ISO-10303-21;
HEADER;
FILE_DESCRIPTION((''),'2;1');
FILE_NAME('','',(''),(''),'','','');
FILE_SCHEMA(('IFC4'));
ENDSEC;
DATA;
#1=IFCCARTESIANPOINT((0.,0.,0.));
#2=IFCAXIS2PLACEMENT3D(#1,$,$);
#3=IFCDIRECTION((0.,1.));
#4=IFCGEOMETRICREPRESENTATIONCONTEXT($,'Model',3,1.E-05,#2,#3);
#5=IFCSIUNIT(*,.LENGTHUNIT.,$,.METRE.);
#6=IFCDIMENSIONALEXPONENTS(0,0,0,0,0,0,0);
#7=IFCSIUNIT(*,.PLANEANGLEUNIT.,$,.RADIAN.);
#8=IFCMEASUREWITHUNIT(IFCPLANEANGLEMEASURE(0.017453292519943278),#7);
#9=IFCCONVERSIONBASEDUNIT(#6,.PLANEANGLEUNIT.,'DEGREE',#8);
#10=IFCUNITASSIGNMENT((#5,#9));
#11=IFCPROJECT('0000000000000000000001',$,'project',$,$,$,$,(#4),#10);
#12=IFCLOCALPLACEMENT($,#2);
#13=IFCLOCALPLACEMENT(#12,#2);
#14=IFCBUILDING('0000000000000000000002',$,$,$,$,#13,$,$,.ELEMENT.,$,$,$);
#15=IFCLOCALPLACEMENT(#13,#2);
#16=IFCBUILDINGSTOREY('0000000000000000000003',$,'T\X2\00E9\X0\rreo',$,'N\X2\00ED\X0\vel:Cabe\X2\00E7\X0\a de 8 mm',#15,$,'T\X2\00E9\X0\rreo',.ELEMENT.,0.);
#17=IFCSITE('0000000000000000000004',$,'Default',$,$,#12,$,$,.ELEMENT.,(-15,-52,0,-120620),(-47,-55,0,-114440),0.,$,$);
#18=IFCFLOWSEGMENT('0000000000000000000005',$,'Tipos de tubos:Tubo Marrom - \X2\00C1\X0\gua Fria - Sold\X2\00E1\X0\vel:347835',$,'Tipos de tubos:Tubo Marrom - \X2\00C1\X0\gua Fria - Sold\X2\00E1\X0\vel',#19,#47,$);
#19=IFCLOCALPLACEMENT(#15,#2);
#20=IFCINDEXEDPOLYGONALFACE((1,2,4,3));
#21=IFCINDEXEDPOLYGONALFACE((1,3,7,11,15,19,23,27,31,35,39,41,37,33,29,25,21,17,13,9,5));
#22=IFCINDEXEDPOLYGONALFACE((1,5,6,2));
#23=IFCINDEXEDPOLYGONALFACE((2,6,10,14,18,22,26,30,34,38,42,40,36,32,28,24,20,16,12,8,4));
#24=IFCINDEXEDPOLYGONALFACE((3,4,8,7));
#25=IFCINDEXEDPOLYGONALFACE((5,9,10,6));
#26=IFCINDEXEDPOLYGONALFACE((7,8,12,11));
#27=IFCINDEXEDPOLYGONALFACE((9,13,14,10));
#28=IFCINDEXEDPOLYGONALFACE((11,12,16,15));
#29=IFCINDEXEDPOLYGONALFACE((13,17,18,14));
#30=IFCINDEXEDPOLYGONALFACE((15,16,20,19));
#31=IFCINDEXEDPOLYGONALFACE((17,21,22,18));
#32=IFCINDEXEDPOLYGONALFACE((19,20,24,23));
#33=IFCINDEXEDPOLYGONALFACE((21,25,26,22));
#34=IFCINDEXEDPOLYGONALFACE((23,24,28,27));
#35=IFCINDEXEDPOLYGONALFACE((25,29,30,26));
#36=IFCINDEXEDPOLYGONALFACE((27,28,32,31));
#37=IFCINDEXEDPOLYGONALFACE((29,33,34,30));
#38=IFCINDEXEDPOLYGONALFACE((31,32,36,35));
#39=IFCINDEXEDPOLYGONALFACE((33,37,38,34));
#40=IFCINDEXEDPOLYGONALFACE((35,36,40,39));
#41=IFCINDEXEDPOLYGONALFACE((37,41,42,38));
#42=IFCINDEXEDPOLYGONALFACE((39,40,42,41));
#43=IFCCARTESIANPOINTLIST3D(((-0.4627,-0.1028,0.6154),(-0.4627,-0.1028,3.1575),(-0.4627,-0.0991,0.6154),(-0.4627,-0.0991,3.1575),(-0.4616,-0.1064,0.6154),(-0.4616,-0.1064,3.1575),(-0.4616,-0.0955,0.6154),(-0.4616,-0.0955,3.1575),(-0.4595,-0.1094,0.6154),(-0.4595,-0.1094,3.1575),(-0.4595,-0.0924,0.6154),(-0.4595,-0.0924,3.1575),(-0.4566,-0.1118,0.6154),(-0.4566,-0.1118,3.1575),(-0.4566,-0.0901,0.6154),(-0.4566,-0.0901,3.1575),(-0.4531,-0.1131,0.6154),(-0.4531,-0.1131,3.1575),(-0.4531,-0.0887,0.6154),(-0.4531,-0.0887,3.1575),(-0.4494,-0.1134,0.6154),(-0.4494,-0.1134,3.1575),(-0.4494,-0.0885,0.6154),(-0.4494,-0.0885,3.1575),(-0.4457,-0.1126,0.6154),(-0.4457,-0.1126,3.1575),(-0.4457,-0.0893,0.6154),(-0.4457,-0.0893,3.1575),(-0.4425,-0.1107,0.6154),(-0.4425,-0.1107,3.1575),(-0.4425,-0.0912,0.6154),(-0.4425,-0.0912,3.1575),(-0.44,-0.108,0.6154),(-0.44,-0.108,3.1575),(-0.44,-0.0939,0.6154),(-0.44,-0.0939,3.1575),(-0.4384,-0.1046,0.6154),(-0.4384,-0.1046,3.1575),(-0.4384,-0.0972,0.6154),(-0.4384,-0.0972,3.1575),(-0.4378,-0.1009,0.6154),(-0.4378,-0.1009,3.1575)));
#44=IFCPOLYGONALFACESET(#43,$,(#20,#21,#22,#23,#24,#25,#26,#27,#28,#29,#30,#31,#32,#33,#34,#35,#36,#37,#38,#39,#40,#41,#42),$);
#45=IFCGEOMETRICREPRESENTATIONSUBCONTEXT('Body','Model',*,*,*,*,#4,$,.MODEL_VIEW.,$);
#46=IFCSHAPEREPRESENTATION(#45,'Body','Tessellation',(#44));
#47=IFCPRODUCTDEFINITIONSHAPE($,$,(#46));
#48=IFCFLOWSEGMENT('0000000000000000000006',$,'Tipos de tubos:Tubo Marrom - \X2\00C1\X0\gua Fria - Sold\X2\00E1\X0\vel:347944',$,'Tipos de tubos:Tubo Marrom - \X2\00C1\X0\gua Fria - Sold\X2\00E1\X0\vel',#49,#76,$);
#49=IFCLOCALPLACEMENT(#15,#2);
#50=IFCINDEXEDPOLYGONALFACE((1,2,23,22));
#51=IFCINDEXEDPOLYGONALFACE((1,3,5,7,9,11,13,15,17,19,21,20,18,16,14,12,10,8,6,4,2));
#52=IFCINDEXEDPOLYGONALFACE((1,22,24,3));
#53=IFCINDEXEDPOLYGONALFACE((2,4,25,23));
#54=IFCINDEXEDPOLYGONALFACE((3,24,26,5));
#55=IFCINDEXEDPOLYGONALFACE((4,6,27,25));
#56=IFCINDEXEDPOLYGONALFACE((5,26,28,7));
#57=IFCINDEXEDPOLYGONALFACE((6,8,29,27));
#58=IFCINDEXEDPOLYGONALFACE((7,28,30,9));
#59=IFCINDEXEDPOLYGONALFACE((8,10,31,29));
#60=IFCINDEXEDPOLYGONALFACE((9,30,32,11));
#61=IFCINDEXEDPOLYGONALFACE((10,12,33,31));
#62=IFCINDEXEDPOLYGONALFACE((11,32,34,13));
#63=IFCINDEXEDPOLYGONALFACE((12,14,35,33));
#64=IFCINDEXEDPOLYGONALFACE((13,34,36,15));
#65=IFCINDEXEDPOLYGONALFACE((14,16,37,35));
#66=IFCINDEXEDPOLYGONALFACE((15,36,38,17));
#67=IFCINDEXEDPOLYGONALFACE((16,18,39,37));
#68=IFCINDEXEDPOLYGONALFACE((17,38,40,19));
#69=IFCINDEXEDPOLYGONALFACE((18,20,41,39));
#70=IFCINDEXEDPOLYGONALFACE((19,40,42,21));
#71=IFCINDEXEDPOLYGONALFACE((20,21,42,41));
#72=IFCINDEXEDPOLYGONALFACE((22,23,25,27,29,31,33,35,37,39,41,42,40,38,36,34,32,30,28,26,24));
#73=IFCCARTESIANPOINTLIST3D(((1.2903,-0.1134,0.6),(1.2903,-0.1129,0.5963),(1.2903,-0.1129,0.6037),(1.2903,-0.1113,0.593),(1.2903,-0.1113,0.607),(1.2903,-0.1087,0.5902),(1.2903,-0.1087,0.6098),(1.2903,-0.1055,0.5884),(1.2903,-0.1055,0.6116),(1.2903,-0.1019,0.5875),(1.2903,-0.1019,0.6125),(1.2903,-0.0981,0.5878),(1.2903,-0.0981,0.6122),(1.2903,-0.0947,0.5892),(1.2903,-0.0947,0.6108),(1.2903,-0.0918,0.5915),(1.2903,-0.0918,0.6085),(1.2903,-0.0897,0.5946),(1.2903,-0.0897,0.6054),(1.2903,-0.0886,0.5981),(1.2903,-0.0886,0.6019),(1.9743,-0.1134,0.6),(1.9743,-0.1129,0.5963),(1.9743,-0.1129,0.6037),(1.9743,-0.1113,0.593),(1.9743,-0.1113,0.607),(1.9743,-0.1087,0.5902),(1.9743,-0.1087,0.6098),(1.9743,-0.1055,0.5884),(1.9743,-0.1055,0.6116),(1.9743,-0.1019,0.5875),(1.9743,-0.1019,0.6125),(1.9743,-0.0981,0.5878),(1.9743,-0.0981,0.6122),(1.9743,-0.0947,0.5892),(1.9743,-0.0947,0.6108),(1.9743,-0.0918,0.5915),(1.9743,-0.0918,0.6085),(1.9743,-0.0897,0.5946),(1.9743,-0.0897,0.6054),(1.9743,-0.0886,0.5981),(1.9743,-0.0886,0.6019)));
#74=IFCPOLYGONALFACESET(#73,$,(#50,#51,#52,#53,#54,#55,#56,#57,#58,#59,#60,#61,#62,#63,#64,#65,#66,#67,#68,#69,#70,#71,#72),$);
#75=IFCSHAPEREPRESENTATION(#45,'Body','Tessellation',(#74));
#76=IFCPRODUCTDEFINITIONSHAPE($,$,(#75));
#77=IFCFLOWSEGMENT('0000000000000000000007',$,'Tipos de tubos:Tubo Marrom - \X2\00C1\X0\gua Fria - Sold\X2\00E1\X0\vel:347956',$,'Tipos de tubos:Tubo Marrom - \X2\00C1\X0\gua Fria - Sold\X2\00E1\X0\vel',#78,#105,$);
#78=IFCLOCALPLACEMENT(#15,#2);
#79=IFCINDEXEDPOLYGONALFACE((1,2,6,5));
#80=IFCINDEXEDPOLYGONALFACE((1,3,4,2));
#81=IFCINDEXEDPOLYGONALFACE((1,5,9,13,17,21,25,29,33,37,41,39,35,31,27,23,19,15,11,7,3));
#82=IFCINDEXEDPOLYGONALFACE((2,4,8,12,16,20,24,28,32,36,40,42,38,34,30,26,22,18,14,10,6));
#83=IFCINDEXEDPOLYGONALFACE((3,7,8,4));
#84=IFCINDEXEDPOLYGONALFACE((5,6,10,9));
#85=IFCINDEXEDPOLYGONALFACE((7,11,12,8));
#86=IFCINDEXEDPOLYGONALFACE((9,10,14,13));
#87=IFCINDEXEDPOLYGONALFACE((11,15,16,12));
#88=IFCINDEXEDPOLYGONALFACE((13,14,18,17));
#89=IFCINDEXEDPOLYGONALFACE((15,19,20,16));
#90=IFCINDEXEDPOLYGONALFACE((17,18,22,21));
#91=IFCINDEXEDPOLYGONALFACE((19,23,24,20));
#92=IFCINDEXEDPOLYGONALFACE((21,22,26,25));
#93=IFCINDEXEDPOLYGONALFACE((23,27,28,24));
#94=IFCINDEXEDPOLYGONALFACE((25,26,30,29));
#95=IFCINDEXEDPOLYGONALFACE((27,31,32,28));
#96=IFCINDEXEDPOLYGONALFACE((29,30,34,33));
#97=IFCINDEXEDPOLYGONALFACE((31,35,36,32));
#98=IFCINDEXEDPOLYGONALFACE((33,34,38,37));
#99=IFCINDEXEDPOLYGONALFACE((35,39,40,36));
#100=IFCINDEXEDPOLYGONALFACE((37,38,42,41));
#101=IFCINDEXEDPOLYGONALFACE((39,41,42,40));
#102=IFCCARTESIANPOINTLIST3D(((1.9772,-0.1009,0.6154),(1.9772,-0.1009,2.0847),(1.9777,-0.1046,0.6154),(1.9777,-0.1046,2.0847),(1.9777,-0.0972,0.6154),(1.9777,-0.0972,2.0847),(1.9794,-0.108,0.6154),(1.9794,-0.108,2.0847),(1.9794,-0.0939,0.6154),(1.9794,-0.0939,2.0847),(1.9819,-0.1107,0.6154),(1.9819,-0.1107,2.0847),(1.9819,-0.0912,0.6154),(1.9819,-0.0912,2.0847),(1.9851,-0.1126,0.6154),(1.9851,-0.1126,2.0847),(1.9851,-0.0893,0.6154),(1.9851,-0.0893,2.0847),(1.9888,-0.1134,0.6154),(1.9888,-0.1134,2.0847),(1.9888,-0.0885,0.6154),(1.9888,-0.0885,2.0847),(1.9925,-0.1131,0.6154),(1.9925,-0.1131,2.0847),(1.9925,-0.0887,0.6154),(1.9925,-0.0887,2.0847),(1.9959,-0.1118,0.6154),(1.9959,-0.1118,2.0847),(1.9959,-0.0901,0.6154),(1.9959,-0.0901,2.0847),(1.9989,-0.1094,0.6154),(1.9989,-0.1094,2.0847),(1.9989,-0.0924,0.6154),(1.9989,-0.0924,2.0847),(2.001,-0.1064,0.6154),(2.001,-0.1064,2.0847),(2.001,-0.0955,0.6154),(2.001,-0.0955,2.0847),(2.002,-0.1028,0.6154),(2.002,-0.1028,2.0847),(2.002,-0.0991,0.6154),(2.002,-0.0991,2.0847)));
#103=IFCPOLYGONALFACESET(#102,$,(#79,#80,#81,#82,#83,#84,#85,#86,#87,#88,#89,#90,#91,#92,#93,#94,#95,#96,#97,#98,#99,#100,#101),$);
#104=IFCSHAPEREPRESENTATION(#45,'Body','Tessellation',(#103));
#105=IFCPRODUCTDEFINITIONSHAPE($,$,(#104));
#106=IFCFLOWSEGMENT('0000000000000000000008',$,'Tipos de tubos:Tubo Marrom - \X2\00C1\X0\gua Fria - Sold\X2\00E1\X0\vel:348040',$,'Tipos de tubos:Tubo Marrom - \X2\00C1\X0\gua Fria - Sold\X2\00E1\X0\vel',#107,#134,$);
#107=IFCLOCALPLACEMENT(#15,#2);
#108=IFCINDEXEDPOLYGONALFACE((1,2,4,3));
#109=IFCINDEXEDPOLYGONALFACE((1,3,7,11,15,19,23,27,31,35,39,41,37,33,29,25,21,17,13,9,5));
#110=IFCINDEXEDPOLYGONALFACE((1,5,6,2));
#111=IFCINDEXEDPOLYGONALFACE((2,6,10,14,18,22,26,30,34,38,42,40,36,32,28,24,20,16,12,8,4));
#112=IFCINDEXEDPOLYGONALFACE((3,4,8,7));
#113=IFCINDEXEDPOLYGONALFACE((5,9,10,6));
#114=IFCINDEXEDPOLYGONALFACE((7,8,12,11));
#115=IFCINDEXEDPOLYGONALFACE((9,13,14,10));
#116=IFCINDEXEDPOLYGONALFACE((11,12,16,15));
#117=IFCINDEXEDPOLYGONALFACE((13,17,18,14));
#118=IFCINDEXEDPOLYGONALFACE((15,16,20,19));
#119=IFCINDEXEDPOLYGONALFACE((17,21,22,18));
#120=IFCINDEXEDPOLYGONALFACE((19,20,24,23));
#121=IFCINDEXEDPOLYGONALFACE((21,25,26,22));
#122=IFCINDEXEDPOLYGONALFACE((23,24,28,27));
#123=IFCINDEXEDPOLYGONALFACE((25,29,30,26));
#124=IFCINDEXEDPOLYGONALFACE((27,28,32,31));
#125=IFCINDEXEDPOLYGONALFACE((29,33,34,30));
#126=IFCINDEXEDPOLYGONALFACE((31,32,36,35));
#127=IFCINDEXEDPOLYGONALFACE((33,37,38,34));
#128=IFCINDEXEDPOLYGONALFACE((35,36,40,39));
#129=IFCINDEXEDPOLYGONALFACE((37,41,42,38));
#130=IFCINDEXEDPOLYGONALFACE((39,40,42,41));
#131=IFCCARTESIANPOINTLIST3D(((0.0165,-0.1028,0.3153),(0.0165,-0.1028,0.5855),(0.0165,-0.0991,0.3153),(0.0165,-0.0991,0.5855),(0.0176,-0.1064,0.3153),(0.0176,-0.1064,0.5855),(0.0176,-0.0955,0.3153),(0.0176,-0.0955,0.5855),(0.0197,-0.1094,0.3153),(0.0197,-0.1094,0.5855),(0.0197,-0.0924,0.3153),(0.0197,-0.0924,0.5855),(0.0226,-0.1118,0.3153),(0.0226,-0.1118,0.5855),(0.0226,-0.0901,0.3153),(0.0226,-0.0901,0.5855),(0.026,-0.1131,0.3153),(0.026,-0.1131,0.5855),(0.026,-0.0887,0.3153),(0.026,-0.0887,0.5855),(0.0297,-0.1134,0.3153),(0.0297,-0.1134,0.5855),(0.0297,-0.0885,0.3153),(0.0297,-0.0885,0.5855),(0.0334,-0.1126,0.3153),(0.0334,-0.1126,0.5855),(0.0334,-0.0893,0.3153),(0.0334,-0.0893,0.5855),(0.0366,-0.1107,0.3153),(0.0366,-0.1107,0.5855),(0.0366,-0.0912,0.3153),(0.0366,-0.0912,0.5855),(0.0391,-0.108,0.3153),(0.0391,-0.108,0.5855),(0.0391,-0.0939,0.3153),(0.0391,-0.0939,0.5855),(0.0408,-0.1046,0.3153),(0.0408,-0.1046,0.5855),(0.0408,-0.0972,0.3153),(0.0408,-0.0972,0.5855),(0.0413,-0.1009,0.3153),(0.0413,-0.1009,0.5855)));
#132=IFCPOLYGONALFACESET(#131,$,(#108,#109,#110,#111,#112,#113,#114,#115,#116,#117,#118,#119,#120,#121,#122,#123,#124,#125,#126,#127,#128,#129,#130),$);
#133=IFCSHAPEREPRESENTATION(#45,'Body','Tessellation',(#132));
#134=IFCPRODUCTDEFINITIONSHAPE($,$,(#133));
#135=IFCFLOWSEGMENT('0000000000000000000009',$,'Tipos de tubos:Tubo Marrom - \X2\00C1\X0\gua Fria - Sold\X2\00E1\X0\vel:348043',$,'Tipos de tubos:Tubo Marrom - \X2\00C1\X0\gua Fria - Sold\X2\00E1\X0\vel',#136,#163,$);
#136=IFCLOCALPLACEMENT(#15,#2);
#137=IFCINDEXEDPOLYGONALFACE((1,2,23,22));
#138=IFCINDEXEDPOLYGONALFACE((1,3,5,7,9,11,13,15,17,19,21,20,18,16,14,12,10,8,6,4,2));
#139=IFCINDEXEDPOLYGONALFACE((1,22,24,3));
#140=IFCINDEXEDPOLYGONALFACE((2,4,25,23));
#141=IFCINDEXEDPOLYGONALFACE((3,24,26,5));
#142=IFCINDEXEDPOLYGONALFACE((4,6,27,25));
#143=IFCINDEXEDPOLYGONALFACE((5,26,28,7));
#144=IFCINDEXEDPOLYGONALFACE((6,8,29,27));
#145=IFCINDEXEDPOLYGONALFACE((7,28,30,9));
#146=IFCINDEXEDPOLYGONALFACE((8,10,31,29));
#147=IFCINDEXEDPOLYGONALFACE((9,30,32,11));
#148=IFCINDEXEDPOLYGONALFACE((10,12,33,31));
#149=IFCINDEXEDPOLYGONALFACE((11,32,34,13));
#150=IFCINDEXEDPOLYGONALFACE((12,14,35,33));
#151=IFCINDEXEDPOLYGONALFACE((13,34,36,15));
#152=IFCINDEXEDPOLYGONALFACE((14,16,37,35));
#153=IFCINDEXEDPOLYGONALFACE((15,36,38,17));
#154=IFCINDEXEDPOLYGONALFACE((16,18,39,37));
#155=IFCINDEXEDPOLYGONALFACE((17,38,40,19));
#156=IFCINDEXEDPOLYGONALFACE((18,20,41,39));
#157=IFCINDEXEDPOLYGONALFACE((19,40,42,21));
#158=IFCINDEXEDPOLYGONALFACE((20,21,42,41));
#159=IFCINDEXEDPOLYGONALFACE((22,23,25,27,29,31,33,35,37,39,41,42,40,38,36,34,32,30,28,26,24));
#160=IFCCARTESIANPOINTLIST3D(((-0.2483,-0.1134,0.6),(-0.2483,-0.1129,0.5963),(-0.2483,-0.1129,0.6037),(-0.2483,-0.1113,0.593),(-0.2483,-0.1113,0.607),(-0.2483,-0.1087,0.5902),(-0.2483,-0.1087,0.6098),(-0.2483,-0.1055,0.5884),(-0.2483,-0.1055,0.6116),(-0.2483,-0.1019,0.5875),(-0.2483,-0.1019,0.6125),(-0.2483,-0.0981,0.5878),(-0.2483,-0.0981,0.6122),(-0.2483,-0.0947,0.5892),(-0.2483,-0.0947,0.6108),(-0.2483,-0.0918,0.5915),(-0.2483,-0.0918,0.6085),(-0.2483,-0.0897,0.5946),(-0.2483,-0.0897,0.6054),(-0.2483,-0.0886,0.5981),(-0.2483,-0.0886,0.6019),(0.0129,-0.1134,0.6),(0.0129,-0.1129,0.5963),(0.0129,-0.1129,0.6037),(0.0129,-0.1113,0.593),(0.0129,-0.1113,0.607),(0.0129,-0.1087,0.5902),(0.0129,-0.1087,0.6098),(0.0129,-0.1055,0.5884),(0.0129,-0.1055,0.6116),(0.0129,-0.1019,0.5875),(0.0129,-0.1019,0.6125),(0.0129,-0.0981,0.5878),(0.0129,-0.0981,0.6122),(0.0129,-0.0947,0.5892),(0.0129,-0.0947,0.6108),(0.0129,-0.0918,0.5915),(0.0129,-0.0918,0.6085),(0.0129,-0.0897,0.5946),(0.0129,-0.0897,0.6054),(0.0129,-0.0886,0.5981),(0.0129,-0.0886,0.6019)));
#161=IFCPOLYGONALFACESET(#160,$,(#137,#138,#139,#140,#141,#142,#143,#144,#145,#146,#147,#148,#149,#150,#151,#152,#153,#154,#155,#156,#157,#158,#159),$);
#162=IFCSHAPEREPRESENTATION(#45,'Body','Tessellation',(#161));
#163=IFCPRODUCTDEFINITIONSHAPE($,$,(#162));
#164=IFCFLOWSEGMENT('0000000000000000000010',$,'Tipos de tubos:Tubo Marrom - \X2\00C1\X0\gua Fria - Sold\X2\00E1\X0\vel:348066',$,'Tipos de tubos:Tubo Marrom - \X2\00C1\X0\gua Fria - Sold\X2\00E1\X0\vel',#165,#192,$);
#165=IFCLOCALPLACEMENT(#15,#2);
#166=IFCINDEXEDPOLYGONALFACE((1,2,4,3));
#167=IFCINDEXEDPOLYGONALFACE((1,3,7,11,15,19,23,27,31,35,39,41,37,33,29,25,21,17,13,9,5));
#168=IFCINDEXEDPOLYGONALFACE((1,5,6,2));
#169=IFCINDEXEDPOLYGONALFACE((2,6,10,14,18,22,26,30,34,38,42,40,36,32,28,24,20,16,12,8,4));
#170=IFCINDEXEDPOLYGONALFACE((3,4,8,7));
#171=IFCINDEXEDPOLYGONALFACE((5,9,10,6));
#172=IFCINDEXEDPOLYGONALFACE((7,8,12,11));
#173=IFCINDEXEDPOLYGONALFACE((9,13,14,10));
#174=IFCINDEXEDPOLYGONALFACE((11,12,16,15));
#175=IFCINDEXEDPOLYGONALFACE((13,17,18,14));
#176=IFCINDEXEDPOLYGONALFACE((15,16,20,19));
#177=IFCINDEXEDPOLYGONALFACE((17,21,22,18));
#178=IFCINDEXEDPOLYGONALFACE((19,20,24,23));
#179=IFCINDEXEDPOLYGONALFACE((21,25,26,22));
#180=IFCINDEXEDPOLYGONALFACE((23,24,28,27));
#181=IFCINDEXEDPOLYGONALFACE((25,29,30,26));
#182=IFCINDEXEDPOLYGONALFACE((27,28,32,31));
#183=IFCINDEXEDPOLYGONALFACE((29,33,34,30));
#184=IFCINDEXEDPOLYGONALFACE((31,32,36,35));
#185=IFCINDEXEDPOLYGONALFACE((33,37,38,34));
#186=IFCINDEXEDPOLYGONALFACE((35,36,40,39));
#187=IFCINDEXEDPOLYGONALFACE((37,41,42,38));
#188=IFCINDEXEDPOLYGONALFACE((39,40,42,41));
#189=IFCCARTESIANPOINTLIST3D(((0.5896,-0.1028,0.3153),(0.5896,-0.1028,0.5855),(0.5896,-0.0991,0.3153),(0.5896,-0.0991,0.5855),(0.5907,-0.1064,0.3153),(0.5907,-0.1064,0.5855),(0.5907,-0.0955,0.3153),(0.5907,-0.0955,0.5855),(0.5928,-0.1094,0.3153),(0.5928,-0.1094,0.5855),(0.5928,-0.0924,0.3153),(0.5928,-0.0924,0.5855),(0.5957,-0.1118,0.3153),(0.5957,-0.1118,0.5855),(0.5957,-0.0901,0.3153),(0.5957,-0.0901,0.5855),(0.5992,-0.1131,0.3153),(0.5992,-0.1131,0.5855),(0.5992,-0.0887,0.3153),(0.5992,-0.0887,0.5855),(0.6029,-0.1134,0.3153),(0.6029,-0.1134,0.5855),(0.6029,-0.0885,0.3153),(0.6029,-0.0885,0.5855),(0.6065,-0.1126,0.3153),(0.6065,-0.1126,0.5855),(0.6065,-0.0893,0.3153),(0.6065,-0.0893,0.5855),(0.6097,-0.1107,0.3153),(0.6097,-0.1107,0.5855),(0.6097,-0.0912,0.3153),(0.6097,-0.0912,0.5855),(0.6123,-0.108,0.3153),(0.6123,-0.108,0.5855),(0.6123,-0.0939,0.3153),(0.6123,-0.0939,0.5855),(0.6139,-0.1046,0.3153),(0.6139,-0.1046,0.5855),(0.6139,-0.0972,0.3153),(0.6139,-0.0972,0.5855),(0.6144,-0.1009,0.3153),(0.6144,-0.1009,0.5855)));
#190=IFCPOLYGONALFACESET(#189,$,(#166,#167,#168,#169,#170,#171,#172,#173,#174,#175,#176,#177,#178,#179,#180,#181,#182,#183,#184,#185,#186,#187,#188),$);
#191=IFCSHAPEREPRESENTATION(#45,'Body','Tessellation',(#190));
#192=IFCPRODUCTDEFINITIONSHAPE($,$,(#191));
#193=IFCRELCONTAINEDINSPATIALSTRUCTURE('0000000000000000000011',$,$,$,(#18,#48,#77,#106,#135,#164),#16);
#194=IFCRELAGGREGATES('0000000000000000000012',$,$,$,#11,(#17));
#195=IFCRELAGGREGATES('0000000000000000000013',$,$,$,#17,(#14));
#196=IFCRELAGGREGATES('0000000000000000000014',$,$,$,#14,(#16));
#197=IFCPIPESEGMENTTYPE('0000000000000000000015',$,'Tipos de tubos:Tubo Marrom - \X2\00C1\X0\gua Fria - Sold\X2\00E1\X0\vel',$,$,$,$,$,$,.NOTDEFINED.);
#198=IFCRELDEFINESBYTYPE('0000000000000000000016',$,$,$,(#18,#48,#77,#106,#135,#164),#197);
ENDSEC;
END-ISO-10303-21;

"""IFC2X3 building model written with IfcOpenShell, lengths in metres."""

from ifc_helpers import new_model, entity, si_unit, converted_unit, direction, frame, frame_2d, origin, origin_2d_with_axis, place, context, subcontext, project, spatial, circle, extrude, type_object, element, save


model = new_model("IFC2X3")

# Units and contexts
model_context = context("Model", 3, precision=1e-05, world=origin(), true_north=direction((0.0, 1.0)))
body_context = subcontext(model_context, "Body", "Model", "MODEL_VIEW")
ifc_project = project(units=[si_unit("LENGTHUNIT", "METRE"), converted_unit("PLANEANGLEUNIT", "DEGREE", entity("IfcPlaneAngleMeasure", 0.017453292519943278), si_unit("PLANEANGLEUNIT", "RADIAN"), dimensions=[0, 0, 0, 0, 0, 0, 0])], contexts=[model_context])

# Site, building, storey
site_placement = place(None, origin())
site = spatial("IfcSite", under=ifc_project, at=site_placement, Name="Default", CompositionType="ELEMENT", RefLatitude=(-15, -52, 0, -120620), RefLongitude=(-47, -55, 0, -114440), RefElevation=0.0)
building_placement = place(site_placement, origin())
building = spatial("IfcBuilding", under=site, at=building_placement, CompositionType="ELEMENT")
storey_placement = place(building_placement, origin())
storey = spatial("IfcBuildingStorey", under=building, at=storey_placement, Name="Térreo", ObjectType="Nível:Cabeça de 8 mm", LongName="Térreo", CompositionType="ELEMENT", Elevation=0.0)

# Flow segments
pipe_segment_type = type_object("IfcPipeSegmentType", Name="Tipos de tubos:Tubo Marrom - Água Fria - Soldável", PredefinedType="NOTDEFINED")
flow_segment_1_placement = place(storey_placement, origin())
element("IfcFlowSegment", 1, at=flow_segment_1_placement, inside=storey, type_object=pipe_segment_type, Name="Tipos de tubos:Tubo Marrom - Água Fria - Soldável:347835", ObjectType="Tipos de tubos:Tubo Marrom - Água Fria - Soldável", context=body_context, shape_type="SweptSolid", body=[
    extrude(circle(Radius=0.0125, at=origin_2d_with_axis()), frame((-0.4503, -0.1009, 0.6154)), (0.0, 0.0, 1.0), 2.5421),
])
flow_segment_2_placement = place(storey_placement, origin())
element("IfcFlowSegment", 2, at=flow_segment_2_placement, inside=storey, type_object=pipe_segment_type, Name="Tipos de tubos:Tubo Marrom - Água Fria - Soldável:347944", ObjectType="Tipos de tubos:Tubo Marrom - Água Fria - Soldável", context=body_context, shape_type="SweptSolid", body=[
    extrude(circle(Radius=0.0125, at=frame_2d((0.0, 0.0), x_axis=(1.0, 0.0))), frame((1.2903, -0.1009, 0.6), z_axis=(1.0, 0.0, 0.0), x_axis=(0.0, -1.0, 0.0)), (0.0, 0.0, 1.0), 0.684),
])
flow_segment_3_placement = place(storey_placement, origin())
element("IfcFlowSegment", 3, at=flow_segment_3_placement, inside=storey, type_object=pipe_segment_type, Name="Tipos de tubos:Tubo Marrom - Água Fria - Soldável:347956", ObjectType="Tipos de tubos:Tubo Marrom - Água Fria - Soldável", context=body_context, shape_type="SweptSolid", body=[
    extrude(circle(Radius=0.0125, at=origin_2d_with_axis()), frame((1.9897, -0.1009, 0.6154), z_axis=(0.0, 0.0, 1.0), x_axis=(-1.0, 0.0, 0.0)), (0.0, 0.0, 1.0), 1.4693),
])
flow_segment_4_placement = place(storey_placement, origin())
element("IfcFlowSegment", 4, at=flow_segment_4_placement, inside=storey, type_object=pipe_segment_type, Name="Tipos de tubos:Tubo Marrom - Água Fria - Soldável:348040", ObjectType="Tipos de tubos:Tubo Marrom - Água Fria - Soldável", context=body_context, shape_type="SweptSolid", body=[
    extrude(circle(Radius=0.0125, at=frame_2d((0.0, 0.0), x_axis=(1.0, 0.0))), frame((0.0288, -0.1009, 0.3153)), (0.0, 0.0, 1.0), 0.2702),
])
flow_segment_5_placement = place(storey_placement, origin())
element("IfcFlowSegment", 5, at=flow_segment_5_placement, inside=storey, type_object=pipe_segment_type, Name="Tipos de tubos:Tubo Marrom - Água Fria - Soldável:348043", ObjectType="Tipos de tubos:Tubo Marrom - Água Fria - Soldável", context=body_context, shape_type="SweptSolid", body=[
    extrude(circle(Radius=0.0125, at=frame_2d((0.0, 0.0), x_axis=(1.0, 0.0))), frame((-0.2483, -0.1009, 0.6), z_axis=(1.0, 0.0, 0.0), x_axis=(0.0, -1.0, 0.0)), (0.0, 0.0, 1.0), 0.2612),
])
flow_segment_6_placement = place(storey_placement, origin())
element("IfcFlowSegment", 6, at=flow_segment_6_placement, inside=storey, type_object=pipe_segment_type, Name="Tipos de tubos:Tubo Marrom - Água Fria - Soldável:348066", ObjectType="Tipos de tubos:Tubo Marrom - Água Fria - Soldável", context=body_context, shape_type="SweptSolid", body=[
    extrude(circle(Radius=0.0125, at=origin_2d_with_axis()), frame((0.6019, -0.1009, 0.3153)), (0.0, 0.0, 1.0), 0.2702),
])

save(model, "model.ifc")
